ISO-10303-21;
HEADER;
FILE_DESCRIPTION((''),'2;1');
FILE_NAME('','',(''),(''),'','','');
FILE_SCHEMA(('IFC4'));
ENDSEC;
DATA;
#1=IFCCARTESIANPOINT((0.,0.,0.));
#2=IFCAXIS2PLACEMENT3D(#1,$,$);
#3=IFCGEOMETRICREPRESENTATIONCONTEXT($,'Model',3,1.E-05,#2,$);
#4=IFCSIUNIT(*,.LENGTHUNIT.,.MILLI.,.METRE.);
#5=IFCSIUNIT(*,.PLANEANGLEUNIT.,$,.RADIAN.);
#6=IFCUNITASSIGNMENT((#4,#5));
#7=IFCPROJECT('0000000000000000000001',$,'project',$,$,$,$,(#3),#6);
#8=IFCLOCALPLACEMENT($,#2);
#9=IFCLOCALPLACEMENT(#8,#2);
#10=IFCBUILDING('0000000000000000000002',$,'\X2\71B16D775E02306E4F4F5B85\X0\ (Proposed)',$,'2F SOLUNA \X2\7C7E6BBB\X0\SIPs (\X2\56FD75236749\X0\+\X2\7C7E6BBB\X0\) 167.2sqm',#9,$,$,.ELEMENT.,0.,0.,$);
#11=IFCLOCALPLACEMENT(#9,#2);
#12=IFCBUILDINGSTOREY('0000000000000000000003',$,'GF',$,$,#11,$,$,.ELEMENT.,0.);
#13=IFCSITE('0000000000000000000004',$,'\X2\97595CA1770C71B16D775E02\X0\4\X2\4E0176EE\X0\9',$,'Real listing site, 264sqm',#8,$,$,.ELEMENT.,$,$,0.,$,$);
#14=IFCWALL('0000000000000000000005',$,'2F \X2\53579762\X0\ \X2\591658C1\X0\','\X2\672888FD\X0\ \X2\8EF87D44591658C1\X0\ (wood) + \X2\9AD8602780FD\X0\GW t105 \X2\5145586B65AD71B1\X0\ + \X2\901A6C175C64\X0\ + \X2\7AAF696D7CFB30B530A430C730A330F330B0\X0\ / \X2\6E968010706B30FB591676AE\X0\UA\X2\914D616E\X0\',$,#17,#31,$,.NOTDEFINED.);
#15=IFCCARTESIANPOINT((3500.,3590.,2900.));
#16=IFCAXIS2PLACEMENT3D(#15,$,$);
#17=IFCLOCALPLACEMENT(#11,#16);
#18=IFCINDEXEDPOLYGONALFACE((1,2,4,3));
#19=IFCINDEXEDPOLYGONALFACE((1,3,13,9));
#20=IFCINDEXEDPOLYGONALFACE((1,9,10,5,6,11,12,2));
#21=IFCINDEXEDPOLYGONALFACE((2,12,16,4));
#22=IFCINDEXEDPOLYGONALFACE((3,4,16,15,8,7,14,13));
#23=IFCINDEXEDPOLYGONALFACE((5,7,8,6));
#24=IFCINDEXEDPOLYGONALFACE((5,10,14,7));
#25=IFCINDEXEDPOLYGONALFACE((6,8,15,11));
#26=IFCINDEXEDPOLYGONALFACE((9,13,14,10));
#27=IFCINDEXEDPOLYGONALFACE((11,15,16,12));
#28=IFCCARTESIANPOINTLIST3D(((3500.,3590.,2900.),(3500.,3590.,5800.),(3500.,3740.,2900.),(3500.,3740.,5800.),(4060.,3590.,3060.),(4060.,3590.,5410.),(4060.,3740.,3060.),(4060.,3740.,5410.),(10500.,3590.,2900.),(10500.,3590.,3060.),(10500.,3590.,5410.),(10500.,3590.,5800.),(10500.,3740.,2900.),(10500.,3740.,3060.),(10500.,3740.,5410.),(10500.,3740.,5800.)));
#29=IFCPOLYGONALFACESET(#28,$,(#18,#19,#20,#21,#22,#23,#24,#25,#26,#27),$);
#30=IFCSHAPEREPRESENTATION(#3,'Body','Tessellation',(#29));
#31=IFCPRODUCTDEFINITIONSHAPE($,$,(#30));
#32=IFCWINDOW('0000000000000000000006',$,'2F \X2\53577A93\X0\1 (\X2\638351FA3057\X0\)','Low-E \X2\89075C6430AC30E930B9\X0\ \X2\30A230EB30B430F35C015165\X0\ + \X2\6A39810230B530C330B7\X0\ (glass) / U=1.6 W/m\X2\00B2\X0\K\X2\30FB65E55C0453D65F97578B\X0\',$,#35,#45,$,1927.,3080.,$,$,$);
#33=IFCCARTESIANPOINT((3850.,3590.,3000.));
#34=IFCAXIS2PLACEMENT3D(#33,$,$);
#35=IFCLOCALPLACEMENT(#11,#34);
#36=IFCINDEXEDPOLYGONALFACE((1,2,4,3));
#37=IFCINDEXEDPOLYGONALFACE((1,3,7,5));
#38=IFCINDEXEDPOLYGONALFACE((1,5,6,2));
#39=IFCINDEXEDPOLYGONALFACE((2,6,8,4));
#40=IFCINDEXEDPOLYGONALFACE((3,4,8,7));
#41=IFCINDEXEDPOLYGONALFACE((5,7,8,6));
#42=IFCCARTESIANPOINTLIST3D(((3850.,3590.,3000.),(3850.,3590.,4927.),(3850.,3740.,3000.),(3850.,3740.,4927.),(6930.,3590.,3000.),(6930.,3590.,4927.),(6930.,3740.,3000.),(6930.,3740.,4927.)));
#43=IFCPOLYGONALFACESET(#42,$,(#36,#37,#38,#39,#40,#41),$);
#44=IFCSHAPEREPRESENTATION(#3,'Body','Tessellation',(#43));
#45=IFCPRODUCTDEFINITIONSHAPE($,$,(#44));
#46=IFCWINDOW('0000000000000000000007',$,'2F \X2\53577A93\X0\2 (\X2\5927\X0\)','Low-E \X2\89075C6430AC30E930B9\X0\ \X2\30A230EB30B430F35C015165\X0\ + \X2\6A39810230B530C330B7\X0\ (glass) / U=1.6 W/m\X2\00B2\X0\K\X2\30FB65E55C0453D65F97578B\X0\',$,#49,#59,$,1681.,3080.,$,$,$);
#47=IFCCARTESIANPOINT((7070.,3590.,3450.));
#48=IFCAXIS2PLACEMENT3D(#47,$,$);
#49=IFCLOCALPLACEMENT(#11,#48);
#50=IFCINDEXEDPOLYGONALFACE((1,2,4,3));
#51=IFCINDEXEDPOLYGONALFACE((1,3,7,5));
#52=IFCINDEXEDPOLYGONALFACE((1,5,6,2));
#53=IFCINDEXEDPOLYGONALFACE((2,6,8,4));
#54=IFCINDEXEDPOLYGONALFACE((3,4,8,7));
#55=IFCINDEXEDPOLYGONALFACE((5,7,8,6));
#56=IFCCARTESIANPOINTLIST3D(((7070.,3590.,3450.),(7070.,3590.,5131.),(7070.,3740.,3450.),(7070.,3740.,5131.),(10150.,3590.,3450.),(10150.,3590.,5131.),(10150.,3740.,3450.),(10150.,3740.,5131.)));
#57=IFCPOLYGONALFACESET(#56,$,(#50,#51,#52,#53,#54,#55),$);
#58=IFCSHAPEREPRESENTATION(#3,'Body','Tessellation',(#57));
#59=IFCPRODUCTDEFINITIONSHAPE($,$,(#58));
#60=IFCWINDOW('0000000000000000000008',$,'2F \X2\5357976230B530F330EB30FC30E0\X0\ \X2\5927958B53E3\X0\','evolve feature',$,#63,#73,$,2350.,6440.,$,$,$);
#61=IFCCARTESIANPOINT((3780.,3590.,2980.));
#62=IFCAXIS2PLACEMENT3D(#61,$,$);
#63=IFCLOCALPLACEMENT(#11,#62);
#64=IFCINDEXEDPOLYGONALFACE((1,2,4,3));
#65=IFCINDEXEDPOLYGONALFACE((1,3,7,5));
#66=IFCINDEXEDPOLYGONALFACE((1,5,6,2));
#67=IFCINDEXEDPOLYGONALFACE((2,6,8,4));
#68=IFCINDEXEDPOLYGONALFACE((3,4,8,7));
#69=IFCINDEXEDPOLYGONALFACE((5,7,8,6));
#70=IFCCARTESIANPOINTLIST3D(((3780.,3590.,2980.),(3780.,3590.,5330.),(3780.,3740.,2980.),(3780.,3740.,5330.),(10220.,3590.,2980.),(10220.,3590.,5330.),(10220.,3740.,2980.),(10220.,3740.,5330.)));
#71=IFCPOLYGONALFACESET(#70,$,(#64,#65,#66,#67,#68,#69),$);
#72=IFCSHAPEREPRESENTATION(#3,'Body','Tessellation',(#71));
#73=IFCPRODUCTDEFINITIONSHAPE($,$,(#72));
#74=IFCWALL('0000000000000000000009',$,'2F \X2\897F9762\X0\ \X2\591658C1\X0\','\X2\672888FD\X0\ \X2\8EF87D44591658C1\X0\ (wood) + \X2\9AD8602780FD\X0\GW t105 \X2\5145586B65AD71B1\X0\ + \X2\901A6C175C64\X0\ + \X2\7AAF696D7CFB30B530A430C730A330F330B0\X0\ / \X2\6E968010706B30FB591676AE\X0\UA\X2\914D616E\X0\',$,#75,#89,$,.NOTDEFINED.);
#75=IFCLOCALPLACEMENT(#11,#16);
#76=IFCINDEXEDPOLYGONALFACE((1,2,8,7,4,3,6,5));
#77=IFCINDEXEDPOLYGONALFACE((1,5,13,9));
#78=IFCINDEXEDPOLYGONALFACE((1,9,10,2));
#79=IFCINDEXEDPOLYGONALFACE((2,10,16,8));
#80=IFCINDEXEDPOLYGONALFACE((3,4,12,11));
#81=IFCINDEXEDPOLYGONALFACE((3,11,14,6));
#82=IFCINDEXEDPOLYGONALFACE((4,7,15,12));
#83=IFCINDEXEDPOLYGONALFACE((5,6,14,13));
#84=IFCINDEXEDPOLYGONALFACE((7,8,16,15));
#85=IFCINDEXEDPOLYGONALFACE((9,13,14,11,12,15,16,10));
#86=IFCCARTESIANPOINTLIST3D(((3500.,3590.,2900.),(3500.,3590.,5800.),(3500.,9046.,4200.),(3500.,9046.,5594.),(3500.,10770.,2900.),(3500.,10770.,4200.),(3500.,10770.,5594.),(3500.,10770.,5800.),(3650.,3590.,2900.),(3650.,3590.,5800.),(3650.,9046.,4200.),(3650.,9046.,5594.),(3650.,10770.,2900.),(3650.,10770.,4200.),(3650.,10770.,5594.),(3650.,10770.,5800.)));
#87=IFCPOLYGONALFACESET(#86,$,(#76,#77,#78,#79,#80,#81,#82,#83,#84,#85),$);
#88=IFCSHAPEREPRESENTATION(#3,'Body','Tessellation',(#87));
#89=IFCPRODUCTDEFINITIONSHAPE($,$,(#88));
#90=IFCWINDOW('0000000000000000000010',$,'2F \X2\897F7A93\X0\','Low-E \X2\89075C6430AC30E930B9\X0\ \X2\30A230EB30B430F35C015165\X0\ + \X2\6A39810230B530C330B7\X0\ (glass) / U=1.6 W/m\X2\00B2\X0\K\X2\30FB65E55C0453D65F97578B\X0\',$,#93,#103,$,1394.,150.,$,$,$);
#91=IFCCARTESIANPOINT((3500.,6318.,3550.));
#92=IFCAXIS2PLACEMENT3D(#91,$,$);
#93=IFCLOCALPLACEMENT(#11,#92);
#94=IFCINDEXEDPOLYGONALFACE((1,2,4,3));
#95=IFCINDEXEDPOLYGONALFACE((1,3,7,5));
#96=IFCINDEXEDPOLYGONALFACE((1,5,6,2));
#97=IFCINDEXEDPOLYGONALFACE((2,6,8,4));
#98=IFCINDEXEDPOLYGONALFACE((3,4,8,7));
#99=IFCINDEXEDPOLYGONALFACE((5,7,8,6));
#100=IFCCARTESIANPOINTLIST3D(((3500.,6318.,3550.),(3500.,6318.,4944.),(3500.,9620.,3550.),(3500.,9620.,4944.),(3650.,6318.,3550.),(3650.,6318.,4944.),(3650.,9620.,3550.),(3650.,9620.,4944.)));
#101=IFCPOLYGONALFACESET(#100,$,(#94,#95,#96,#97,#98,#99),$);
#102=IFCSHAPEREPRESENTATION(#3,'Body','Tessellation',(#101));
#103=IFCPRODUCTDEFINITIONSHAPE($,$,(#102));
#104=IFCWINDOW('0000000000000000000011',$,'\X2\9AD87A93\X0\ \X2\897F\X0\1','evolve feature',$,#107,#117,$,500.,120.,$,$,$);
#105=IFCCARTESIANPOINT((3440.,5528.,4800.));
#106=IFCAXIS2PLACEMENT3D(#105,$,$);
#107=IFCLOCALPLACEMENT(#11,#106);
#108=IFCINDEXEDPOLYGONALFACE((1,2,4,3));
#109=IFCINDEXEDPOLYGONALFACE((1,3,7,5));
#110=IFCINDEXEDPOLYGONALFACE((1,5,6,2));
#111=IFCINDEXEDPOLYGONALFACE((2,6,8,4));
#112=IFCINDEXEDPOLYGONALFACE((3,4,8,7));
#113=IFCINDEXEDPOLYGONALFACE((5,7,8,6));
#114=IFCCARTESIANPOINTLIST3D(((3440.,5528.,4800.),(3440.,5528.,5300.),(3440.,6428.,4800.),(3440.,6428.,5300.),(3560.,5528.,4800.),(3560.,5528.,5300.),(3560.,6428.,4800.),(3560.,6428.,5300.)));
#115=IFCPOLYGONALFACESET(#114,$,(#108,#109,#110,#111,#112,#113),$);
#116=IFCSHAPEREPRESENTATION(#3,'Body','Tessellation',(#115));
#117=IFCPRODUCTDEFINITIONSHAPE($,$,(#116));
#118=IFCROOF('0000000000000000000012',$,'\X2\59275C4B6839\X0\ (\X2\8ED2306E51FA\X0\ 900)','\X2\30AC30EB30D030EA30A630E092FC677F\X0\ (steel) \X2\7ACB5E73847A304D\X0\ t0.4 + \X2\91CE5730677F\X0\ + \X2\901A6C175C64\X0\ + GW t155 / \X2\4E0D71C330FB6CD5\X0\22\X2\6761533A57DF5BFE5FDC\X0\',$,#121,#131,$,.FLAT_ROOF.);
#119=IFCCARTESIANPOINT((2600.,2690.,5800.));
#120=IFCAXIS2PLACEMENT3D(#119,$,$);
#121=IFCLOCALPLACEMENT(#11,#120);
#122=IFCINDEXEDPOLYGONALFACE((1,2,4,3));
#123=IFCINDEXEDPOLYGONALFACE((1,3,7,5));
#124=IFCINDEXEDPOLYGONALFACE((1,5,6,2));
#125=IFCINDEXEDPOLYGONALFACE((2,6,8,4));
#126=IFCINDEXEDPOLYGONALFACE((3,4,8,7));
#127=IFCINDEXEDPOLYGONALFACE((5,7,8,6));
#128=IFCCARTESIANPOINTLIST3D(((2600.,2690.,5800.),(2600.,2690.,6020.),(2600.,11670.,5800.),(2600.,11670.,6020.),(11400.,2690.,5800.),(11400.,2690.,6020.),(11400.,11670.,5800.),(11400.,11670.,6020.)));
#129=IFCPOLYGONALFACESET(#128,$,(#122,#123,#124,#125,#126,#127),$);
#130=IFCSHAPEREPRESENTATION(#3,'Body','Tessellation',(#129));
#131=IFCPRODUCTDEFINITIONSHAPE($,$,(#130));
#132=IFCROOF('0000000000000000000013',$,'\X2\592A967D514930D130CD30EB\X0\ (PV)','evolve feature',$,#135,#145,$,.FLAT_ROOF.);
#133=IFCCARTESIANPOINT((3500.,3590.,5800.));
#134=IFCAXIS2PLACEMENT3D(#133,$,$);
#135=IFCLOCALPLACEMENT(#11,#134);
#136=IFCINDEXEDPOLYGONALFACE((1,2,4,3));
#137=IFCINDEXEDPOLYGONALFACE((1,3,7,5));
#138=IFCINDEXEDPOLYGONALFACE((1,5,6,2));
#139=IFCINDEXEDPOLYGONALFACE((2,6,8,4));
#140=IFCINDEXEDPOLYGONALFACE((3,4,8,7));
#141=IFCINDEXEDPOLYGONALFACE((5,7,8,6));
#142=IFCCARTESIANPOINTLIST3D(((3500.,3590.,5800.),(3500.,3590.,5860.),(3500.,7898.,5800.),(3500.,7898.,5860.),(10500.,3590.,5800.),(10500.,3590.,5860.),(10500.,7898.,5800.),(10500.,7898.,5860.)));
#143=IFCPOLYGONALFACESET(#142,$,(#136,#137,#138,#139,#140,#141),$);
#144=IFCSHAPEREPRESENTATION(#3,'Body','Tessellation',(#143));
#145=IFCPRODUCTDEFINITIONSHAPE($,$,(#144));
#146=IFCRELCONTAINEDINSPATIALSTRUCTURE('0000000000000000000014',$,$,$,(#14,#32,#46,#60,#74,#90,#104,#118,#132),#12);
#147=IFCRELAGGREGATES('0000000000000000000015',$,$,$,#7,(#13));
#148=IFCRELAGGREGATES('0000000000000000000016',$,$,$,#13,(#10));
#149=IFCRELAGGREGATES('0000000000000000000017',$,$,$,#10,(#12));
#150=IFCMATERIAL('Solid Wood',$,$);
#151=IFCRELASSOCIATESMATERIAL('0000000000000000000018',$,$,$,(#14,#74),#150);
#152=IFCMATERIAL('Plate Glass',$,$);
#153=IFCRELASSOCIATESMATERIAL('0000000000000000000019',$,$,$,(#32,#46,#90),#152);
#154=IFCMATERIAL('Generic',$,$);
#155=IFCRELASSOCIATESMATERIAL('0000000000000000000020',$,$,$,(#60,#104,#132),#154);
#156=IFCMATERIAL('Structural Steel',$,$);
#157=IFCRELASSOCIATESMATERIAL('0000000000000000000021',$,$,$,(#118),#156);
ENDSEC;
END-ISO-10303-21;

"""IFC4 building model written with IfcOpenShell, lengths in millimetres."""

from ifc_helpers import new_model, si_unit, frame, frame_2d, origin, place, context, project, spatial, rectangle, extrude, material, element, fill, save


model = new_model("IFC4")

# Units and contexts
model_context = context("Model", 3, precision=1e-05, world=origin())
ifc_project = project(units=[si_unit("LENGTHUNIT", "METRE", prefix="MILLI"), si_unit("PLANEANGLEUNIT", "RADIAN")], contexts=[model_context])

# Site, building, storey
site_placement = place(None, origin())
site = spatial("IfcSite", under=ifc_project, at=site_placement, Name="静岡県熱海市4丁目9", ObjectType="Real listing site, 264sqm", CompositionType="ELEMENT", RefElevation=0.0)
building_placement = place(site_placement, origin())
building = spatial("IfcBuilding", under=site, at=building_placement, Name="熱海市の住宅 (Proposed)", ObjectType="2F SOLUNA 籾殻SIPs (国産杉+籾殻) 167.2sqm", CompositionType="ELEMENT", ElevationOfRefHeight=0.0, ElevationOfTerrain=0.0)
storey_placement = place(building_placement, origin())
storey = spatial("IfcBuildingStorey", under=building, at=storey_placement, Name="GF", CompositionType="ELEMENT", Elevation=0.0)

# Shared definitions
ifc_material_1 = material(Name="Solid Wood")
ifc_material_2 = material(Name="Generic")

# Shared definitions
ifc_material_3 = material(Name="Plate Glass")

# Walls, openings, windows
wall_1_placement = place(storey_placement, frame((3500.0, 3590.0, 2900.0)))
wall_1 = element("IfcWall", 1, at=wall_1_placement, inside=storey, material=ifc_material_1, Name="2F 南面 外壁", Description="木製 軸組外壁 (wood) + 高性能GW t105 充填断熱 + 通気層 + 窯業系サイディング / 準耐火・外皮UA配慮", PredefinedType="NOTDEFINED", context=model_context, shape_type="SweptSolid", body=[
    extrude(rectangle(XDim=7000.0, YDim=150.0, at=frame_2d((3500.0, 75.0))), frame((3500.0, 3590.0, 2900.0)), (0.0, 0.0, 1.0), 2900.0),
])
opening_1_placement = place(storey_placement, frame((3850.0, 3590.0, 3000.0)))
opening_1 = element("IfcOpeningElement", 2, at=opening_1_placement, cuts=wall_1, PredefinedType="NOTDEFINED", context=model_context, shape_type="SweptSolid", body=[
    extrude(rectangle(XDim=3080.0, YDim=150.0, at=frame_2d((1540.0, 75.0))), frame((3850.0, 3590.0, 3000.0)), (0.0, 0.0, 1.0), 1927.0),
])
opening_2_placement = place(storey_placement, frame((7070.0, 3590.0, 3450.0)))
opening_2 = element("IfcOpeningElement", 3, at=opening_2_placement, cuts=wall_1, PredefinedType="NOTDEFINED", context=model_context, shape_type="SweptSolid", body=[
    extrude(rectangle(XDim=3080.0, YDim=150.0, at=frame_2d((1540.0, 75.0))), frame((7070.0, 3590.0, 3450.0)), (0.0, 0.0, 1.0), 1681.0),
])
opening_3_placement = place(storey_placement, frame((3780.0, 3590.0, 2980.0)))
opening_3 = element("IfcOpeningElement", 4, at=opening_3_placement, cuts=wall_1, PredefinedType="NOTDEFINED", context=model_context, shape_type="SweptSolid", body=[
    extrude(rectangle(XDim=6440.0, YDim=150.0, at=frame_2d((3220.0, 75.0))), frame((3780.0, 3590.0, 2980.0)), (0.0, 0.0, 1.0), 2350.0),
])
window_1_placement = place(storey_placement, frame((3850.0, 3590.0, 3000.0)))
window_1 = element("IfcWindow", 5, at=window_1_placement, inside=storey, material=ifc_material_3, Name="2F 南窓1 (掃出し)", Description="Low-E 複層ガラス アルゴン封入 + 樹脂サッシ (glass) / U=1.6 W/m²K・日射取得型", OverallHeight=1927.0, OverallWidth=3080.0, context=model_context, shape_type="SweptSolid", body=[
    extrude(rectangle(XDim=3080.0, YDim=150.0, at=frame_2d((1540.0, 75.0))), frame((3850.0, 3590.0, 3000.0)), (0.0, 0.0, 1.0), 1927.0),
])
fill(opening_1, window_1)
window_2_placement = place(storey_placement, frame((7070.0, 3590.0, 3450.0)))
window_2 = element("IfcWindow", 6, at=window_2_placement, inside=storey, material=ifc_material_3, Name="2F 南窓2 (大)", Description="Low-E 複層ガラス アルゴン封入 + 樹脂サッシ (glass) / U=1.6 W/m²K・日射取得型", OverallHeight=1681.0, OverallWidth=3080.0, context=model_context, shape_type="SweptSolid", body=[
    extrude(rectangle(XDim=3080.0, YDim=150.0, at=frame_2d((1540.0, 75.0))), frame((7070.0, 3590.0, 3450.0)), (0.0, 0.0, 1.0), 1681.0),
])
fill(opening_2, window_2)
window_3_placement = place(storey_placement, frame((3780.0, 3590.0, 2980.0)))
window_3 = element("IfcWindow", 7, at=window_3_placement, inside=storey, material=ifc_material_2, Name="2F 南面サンルーム 大開口", Description="evolve feature", OverallHeight=2350.0, OverallWidth=6440.0, context=model_context, shape_type="SweptSolid", body=[
    extrude(rectangle(XDim=6440.0, YDim=150.0, at=frame_2d((3220.0, 75.0))), frame((3780.0, 3590.0, 2980.0)), (0.0, 0.0, 1.0), 2350.0),
])
fill(opening_3, window_3)
wall_2_placement = place(storey_placement, frame((3500.0, 3590.0, 2900.0)))
wall_2 = element("IfcWall", 8, at=wall_2_placement, inside=storey, material=ifc_material_1, Name="2F 西面 外壁", Description="木製 軸組外壁 (wood) + 高性能GW t105 充填断熱 + 通気層 + 窯業系サイディング / 準耐火・外皮UA配慮", PredefinedType="NOTDEFINED", context=model_context, shape_type="SweptSolid", body=[
    extrude(rectangle(XDim=150.0, YDim=7180.0, at=frame_2d((75.0, 3590.0))), frame((3500.0, 3590.0, 2900.0)), (0.0, 0.0, 1.0), 2900.0),
])
opening_4_placement = place(storey_placement, frame((3500.0, 6318.0, 3550.0)))
opening_4 = element("IfcOpeningElement", 9, at=opening_4_placement, cuts=wall_2, PredefinedType="NOTDEFINED", context=model_context, shape_type="SweptSolid", body=[
    extrude(rectangle(XDim=150.0, YDim=3302.0, at=frame_2d((75.0, 1651.0))), frame((3500.0, 6318.0, 3550.0)), (0.0, 0.0, 1.0), 1394.0),
])
opening_5_placement = place(storey_placement, frame((3440.0, 5528.0, 4800.0)))
opening_5 = element("IfcOpeningElement", 10, at=opening_5_placement, cuts=wall_2, PredefinedType="NOTDEFINED", context=model_context, shape_type="SweptSolid", body=[
    extrude(rectangle(XDim=120.0, YDim=900.0, at=frame_2d((60.0, 450.0))), frame((3440.0, 5528.0, 4800.0)), (0.0, 0.0, 1.0), 500.0),
])
window_4_placement = place(storey_placement, frame((3500.0, 6318.0, 3550.0)))
window_4 = element("IfcWindow", 11, at=window_4_placement, inside=storey, material=ifc_material_3, Name="2F 西窓", Description="Low-E 複層ガラス アルゴン封入 + 樹脂サッシ (glass) / U=1.6 W/m²K・日射取得型", OverallHeight=1394.0, OverallWidth=150.0, context=model_context, shape_type="SweptSolid", body=[
    extrude(rectangle(XDim=150.0, YDim=3302.0, at=frame_2d((75.0, 1651.0))), frame((3500.0, 6318.0, 3550.0)), (0.0, 0.0, 1.0), 1394.0),
])
fill(opening_4, window_4)
window_5_placement = place(storey_placement, frame((3440.0, 5528.0, 4800.0)))
window_5 = element("IfcWindow", 12, at=window_5_placement, inside=storey, material=ifc_material_2, Name="高窓 西1", Description="evolve feature", OverallHeight=500.0, OverallWidth=120.0, context=model_context, shape_type="SweptSolid", body=[
    extrude(rectangle(XDim=120.0, YDim=900.0, at=frame_2d((60.0, 450.0))), frame((3440.0, 5528.0, 4800.0)), (0.0, 0.0, 1.0), 500.0),
])
fill(opening_5, window_5)

# Roofs
ifc_material_4 = material(Name="Structural Steel")
roof_1_placement = place(storey_placement, frame((2600.0, 2690.0, 5800.0)))
element("IfcRoof", 13, at=roof_1_placement, inside=storey, material=ifc_material_4, Name="大屋根 (軒の出 900)", Description="ガルバリウム鋼板 (steel) 立平葺き t0.4 + 野地板 + 通気層 + GW t155 / 不燃・法22条区域対応", PredefinedType="FLAT_ROOF", context=model_context, shape_type="SweptSolid", body=[
    extrude(rectangle(XDim=8800.0, YDim=8980.0, at=frame_2d((4400.0, 4490.0))), frame((2600.0, 2690.0, 5800.0)), (0.0, 0.0, 1.0), 220.0),
])
roof_2_placement = place(storey_placement, frame((3500.0, 3590.0, 5800.0)))
element("IfcRoof", 14, at=roof_2_placement, inside=storey, material=ifc_material_2, Name="太陽光パネル (PV)", Description="evolve feature", PredefinedType="FLAT_ROOF", context=model_context, shape_type="SweptSolid", body=[
    extrude(rectangle(XDim=7000.0, YDim=4308.0, at=frame_2d((3500.0, 2154.0))), frame((3500.0, 3590.0, 5800.0)), (0.0, 0.0, 1.0), 60.0),
])

save(model, "model.ifc")
